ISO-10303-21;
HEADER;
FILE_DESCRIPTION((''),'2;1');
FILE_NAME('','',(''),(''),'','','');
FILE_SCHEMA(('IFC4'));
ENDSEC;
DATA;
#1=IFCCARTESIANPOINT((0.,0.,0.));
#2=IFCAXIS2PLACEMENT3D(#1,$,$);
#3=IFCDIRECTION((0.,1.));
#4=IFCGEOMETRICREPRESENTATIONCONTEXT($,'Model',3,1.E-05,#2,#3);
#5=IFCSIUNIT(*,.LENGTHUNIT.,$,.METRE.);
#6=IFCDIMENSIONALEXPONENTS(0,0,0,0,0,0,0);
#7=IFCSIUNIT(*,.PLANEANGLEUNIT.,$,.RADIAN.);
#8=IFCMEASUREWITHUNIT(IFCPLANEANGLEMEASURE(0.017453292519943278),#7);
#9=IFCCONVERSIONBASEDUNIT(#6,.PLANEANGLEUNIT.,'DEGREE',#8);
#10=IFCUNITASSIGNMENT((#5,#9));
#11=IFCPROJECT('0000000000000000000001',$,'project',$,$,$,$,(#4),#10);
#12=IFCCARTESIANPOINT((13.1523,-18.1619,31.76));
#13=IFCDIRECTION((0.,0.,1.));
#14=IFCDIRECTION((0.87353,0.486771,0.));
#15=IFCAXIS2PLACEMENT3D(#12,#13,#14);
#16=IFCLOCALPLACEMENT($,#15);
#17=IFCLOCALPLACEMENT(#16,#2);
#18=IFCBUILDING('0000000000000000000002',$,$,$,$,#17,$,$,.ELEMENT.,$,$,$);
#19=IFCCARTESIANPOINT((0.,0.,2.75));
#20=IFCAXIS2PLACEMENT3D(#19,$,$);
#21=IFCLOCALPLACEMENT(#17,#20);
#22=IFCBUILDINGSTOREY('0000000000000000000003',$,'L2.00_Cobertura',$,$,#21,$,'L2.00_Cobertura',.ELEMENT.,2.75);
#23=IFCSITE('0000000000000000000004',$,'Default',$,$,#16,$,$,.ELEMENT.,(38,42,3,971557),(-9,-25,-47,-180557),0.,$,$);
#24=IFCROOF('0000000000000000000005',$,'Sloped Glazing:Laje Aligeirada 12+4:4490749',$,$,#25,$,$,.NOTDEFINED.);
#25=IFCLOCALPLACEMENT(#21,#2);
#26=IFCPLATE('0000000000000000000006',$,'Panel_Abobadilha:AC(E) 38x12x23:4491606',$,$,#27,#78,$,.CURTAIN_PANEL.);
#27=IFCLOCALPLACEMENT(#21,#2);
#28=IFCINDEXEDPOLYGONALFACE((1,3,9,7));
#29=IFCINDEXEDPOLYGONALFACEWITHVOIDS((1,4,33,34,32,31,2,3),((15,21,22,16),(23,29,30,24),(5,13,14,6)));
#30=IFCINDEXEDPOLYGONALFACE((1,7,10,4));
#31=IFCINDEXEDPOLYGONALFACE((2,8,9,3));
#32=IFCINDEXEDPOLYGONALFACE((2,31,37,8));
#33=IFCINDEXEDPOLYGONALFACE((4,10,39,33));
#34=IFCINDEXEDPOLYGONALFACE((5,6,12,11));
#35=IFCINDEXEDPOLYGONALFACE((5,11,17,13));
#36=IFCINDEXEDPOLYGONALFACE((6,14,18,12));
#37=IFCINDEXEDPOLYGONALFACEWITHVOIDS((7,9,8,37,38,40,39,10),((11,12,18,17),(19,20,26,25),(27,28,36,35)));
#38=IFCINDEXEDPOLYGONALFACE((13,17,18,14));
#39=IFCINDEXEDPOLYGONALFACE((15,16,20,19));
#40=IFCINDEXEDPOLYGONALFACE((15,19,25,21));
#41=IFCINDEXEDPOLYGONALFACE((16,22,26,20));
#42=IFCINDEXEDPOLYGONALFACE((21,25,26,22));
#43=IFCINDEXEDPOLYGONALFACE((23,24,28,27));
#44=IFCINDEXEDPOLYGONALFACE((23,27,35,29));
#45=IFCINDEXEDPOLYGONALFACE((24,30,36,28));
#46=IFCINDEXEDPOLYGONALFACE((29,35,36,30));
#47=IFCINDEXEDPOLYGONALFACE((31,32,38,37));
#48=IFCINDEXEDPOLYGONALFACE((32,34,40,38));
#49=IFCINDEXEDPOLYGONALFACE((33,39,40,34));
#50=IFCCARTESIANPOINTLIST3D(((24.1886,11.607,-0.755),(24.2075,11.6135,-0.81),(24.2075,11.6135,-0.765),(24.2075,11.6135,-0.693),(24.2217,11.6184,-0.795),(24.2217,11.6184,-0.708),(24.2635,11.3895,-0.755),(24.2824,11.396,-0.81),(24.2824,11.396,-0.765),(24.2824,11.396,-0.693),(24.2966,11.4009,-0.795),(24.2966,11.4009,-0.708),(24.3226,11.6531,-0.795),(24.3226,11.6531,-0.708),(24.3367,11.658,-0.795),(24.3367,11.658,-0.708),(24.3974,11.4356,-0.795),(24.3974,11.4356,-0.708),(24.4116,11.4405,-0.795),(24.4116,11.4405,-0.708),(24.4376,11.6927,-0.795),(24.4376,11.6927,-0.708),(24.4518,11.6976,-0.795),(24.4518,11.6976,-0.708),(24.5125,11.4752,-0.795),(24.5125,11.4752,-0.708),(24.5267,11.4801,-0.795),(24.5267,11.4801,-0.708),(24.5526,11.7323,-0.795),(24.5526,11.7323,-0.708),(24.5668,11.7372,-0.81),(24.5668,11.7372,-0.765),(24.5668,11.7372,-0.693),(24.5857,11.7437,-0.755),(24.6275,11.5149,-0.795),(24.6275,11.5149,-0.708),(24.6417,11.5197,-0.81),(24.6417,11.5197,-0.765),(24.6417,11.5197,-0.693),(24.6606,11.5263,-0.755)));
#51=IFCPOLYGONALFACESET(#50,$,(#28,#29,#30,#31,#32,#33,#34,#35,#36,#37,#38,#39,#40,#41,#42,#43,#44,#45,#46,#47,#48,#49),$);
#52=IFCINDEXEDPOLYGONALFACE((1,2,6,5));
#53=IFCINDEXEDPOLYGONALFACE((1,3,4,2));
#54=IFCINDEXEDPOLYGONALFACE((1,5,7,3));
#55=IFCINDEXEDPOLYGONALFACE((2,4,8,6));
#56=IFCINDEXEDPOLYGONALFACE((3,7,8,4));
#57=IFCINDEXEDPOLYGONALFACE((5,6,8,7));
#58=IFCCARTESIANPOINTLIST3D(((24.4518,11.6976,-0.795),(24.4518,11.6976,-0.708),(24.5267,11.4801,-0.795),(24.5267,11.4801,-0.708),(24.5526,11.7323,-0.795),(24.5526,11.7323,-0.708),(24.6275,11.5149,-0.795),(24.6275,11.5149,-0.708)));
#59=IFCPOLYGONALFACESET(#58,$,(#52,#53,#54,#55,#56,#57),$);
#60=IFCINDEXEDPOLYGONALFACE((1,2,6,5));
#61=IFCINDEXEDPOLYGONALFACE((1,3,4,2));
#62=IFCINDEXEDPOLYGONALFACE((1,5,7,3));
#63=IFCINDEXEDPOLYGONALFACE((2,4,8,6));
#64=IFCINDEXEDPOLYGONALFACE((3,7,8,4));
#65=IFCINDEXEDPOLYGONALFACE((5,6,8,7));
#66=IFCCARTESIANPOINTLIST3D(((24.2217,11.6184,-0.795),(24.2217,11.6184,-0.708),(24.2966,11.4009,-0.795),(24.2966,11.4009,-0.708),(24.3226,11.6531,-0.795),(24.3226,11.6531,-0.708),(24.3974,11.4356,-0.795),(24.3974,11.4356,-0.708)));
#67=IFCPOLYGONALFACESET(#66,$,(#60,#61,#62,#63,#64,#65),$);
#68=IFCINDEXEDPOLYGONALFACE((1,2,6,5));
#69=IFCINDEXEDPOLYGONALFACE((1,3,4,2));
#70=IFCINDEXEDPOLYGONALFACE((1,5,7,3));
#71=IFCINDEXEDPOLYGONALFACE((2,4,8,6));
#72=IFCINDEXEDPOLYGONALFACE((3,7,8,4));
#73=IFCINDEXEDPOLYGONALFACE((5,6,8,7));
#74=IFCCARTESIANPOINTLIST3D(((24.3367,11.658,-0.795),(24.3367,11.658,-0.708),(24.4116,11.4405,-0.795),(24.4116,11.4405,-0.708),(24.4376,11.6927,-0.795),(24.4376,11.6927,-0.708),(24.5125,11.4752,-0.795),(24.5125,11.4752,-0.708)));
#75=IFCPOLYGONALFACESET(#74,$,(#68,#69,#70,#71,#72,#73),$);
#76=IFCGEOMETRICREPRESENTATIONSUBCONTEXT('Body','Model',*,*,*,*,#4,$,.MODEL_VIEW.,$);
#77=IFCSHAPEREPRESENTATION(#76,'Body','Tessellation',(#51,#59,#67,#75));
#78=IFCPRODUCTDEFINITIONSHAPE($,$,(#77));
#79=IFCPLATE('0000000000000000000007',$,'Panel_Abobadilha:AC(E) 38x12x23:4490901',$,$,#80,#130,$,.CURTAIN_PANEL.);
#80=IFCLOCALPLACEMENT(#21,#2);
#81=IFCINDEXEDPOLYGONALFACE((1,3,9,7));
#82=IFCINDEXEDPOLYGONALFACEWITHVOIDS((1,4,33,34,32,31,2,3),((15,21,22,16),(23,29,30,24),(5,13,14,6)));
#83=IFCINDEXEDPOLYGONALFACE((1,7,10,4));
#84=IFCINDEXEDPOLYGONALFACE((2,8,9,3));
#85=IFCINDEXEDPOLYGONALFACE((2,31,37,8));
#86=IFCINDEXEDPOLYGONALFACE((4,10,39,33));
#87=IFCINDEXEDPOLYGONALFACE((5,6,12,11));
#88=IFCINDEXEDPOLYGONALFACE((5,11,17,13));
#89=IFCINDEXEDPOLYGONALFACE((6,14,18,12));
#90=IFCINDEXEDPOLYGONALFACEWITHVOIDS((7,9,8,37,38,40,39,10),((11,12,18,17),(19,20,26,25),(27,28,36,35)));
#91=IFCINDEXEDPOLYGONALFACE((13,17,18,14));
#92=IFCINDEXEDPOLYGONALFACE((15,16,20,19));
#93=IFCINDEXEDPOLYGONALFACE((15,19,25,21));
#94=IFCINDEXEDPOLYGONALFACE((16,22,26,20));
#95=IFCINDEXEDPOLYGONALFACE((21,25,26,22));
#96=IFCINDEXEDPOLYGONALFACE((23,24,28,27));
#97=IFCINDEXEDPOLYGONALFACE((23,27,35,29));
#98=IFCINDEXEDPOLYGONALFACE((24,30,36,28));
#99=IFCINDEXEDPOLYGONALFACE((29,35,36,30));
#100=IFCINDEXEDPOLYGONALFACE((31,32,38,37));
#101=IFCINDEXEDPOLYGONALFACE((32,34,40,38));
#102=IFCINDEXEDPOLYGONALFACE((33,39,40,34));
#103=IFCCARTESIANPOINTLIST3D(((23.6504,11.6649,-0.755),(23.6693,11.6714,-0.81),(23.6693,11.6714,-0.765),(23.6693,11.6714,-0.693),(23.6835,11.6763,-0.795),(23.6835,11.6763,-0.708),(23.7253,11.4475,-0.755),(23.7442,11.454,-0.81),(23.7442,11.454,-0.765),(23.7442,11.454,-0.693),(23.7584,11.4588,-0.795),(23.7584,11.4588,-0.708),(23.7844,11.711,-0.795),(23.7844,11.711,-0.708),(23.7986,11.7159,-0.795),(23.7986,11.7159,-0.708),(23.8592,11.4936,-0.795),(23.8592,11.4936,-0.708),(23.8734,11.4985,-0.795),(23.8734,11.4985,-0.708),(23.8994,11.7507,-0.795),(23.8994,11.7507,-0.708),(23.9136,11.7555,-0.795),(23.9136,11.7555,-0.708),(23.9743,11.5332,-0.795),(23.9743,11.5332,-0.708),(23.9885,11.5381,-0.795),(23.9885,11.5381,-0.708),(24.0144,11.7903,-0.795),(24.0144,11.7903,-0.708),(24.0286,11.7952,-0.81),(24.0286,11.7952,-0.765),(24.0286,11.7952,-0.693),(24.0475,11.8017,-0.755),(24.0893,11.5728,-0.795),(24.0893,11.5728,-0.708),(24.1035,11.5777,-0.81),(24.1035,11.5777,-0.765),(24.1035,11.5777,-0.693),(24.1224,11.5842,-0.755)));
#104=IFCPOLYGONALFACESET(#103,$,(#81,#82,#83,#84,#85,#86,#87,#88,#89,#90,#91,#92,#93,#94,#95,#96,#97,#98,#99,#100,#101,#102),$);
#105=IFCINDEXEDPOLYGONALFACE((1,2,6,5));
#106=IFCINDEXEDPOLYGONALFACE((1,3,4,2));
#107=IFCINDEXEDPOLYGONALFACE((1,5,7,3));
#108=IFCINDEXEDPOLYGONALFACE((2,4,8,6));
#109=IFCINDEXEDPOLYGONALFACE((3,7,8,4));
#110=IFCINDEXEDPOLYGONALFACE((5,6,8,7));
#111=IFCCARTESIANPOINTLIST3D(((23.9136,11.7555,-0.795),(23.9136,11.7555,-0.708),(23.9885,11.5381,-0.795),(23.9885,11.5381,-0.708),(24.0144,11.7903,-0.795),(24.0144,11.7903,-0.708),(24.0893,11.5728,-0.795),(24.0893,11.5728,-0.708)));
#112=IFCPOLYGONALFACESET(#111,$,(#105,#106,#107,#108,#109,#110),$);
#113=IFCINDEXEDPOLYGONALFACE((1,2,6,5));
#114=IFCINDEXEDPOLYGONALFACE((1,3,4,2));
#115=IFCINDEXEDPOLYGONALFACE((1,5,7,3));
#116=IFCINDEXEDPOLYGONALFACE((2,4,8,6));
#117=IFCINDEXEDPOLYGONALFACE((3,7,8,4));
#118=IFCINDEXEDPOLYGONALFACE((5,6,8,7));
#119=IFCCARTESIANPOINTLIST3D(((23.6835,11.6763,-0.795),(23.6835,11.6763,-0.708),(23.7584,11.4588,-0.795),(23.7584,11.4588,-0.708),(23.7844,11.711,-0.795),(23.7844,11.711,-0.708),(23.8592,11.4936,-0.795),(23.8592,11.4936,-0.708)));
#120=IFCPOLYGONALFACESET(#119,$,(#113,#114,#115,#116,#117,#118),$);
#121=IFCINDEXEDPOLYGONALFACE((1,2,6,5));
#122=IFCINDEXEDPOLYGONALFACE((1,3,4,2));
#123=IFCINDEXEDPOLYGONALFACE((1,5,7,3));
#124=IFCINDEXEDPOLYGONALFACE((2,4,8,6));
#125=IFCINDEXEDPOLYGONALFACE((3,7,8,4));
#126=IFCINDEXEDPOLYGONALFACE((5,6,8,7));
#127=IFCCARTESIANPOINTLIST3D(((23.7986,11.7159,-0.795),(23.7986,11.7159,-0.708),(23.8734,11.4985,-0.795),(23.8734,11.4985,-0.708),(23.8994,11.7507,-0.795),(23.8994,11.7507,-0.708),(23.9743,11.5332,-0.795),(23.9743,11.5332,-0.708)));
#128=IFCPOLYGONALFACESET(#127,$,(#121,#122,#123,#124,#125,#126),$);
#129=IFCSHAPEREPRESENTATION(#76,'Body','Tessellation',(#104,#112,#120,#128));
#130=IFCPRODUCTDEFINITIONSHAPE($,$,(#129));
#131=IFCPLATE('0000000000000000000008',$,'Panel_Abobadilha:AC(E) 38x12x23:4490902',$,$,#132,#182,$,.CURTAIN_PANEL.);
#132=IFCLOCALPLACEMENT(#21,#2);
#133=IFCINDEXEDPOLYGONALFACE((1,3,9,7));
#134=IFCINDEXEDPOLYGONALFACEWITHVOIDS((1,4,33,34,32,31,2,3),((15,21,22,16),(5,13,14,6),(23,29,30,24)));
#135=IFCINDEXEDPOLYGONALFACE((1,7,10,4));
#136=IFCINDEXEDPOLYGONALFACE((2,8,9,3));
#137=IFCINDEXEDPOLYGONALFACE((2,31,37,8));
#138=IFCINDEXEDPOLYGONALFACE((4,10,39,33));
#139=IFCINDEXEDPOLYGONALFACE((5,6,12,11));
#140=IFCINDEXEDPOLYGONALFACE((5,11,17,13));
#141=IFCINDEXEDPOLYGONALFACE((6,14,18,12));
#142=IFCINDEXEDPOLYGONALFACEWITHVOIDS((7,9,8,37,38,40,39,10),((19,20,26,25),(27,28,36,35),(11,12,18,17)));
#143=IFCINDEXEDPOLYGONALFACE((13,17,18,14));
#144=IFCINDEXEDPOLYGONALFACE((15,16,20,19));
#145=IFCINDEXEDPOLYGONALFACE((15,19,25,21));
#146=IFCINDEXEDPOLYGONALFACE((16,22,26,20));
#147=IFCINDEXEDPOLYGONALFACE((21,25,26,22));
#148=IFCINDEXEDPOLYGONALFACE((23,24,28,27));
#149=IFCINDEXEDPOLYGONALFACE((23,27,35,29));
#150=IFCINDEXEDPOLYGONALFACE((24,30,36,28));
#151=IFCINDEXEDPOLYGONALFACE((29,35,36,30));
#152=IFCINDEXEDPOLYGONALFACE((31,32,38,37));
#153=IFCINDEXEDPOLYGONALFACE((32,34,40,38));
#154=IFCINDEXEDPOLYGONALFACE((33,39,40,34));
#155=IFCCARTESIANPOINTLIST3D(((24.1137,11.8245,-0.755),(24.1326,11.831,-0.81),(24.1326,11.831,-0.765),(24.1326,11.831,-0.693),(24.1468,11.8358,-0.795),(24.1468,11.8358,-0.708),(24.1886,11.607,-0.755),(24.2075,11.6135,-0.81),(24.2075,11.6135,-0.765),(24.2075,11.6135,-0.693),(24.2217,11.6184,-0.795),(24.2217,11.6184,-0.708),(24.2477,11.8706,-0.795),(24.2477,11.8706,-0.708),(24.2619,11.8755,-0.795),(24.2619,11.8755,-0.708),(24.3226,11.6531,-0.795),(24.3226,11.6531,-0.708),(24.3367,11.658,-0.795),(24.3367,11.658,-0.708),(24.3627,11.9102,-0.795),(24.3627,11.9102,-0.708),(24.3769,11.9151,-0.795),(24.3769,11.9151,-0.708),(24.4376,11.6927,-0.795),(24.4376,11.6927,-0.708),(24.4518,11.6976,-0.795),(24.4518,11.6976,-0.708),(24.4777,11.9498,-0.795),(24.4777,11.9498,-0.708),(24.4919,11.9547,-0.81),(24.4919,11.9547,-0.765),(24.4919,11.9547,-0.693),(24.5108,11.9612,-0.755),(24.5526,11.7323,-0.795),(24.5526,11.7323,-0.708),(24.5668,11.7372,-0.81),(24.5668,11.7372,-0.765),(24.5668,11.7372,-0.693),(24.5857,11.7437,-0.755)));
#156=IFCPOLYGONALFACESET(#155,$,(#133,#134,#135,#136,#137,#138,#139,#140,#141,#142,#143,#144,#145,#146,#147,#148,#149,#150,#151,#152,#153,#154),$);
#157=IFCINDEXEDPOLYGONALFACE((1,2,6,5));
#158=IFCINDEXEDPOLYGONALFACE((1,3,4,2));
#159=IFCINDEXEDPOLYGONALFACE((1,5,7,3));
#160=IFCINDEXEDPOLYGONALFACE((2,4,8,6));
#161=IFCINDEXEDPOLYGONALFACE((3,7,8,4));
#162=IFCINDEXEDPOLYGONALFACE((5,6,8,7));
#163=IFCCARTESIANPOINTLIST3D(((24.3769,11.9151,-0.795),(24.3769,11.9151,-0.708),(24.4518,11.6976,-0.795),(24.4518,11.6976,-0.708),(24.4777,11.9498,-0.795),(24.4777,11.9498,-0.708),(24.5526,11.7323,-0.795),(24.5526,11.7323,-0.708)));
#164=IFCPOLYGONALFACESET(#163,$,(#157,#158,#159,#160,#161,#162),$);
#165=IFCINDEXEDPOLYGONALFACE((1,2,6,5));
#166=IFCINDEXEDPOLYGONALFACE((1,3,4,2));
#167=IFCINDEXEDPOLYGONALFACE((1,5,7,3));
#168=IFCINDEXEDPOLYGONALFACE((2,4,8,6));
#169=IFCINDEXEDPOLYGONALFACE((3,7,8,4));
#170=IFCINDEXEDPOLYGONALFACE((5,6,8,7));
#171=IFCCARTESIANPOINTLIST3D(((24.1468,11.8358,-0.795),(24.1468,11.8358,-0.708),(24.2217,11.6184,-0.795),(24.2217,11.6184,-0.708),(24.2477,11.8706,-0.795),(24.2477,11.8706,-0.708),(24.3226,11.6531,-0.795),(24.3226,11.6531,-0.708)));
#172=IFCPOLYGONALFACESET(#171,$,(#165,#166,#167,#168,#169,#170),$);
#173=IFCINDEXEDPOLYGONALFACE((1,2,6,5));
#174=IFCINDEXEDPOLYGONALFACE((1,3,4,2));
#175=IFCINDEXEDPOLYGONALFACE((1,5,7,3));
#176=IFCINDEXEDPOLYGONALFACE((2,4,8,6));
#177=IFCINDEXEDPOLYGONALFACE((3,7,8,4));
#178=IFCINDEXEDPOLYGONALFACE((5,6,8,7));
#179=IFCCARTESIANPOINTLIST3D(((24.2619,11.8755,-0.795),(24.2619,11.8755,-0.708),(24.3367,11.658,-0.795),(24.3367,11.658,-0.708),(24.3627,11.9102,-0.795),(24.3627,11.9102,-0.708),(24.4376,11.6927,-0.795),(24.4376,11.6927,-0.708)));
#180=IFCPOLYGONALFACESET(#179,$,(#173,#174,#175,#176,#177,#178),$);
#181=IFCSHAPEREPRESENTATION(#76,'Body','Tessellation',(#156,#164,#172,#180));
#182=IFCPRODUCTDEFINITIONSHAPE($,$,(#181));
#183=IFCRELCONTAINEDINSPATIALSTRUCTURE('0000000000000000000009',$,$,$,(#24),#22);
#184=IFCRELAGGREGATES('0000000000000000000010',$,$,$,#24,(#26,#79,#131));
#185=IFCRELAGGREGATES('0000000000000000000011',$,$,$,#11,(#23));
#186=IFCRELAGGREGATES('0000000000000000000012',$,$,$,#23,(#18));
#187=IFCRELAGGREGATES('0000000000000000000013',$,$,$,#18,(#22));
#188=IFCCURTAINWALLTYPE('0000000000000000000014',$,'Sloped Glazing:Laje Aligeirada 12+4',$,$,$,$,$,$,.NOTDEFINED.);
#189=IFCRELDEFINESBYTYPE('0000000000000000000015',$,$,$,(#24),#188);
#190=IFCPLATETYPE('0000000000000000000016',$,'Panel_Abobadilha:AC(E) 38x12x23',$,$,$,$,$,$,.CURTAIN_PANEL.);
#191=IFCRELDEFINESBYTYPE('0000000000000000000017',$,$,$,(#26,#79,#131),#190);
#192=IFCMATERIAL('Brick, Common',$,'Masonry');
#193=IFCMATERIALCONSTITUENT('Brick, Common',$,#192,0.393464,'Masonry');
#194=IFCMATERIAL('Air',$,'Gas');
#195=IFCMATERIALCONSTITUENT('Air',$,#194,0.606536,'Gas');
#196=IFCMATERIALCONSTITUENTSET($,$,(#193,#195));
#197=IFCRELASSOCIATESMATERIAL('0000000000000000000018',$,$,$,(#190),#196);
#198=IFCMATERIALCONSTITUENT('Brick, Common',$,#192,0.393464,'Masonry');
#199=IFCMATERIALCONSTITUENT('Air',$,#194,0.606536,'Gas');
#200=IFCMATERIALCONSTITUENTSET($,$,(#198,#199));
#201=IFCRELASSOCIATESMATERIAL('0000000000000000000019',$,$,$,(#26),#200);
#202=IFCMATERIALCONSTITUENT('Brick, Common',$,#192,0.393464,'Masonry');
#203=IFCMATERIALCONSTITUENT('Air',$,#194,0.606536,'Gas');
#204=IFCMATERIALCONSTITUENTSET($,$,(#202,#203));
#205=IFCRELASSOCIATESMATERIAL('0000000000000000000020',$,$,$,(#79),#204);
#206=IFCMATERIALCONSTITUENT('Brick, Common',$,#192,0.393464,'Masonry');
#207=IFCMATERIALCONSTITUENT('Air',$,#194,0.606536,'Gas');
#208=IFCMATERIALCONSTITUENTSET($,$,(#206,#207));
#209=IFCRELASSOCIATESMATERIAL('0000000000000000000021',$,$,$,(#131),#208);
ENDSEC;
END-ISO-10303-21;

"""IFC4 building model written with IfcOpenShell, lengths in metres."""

from ifc_helpers import new_model, entity, si_unit, converted_unit, direction, frame, origin, place, context, subcontext, project, spatial, indexed_curve, outline, extrude, source, transform, mapped, material, constituent, constituent_set, type_object, type_shapes, element, aggregate, save


model = new_model("IFC4")

# Units and contexts
model_context = context("Model", 3, precision=1e-05, world=origin(), true_north=direction((0.0, 1.0)))
body_context = subcontext(model_context, "Body", "Model", "MODEL_VIEW")
ifc_project = project(units=[si_unit("LENGTHUNIT", "METRE"), converted_unit("PLANEANGLEUNIT", "DEGREE", entity("IfcPlaneAngleMeasure", 0.017453292519943278), si_unit("PLANEANGLEUNIT", "RADIAN"), dimensions=[0, 0, 0, 0, 0, 0, 0])], contexts=[model_context])

# Site, building, storey
site_placement = place(None, frame((13.1523, -18.1619, 31.76), z_axis=(0.0, 0.0, 1.0), x_axis=(0.87353, 0.486771, 0.0)))
site = spatial("IfcSite", under=ifc_project, at=site_placement, Name="Default", CompositionType="ELEMENT", RefLatitude=(38, 42, 3, 971557), RefLongitude=(-9, -25, -47, -180557), RefElevation=0.0)
building_placement = place(site_placement, origin())
building = spatial("IfcBuilding", under=site, at=building_placement, CompositionType="ELEMENT")
storey_placement = place(building_placement, frame((0.0, 0.0, 2.75)))
storey = spatial("IfcBuildingStorey", under=building, at=storey_placement, Name="L2.00_Cobertura", LongName="L2.00_Cobertura", CompositionType="ELEMENT", Elevation=2.75)

# Roof, plates
curtain_wall_type = type_object("IfcCurtainWallType", Name="Sloped Glazing:Laje Aligeirada 12+4", PredefinedType="NOTDEFINED")
roof_placement = place(storey_placement, frame((0.0, 0.0, -2.75)))
roof = element("IfcRoof", 1, at=roof_placement, inside=storey, type_object=curtain_wall_type, Name="Sloped Glazing:Laje Aligeirada 12+4:4490749", PredefinedType="NOTDEFINED")
ifc_material_1 = material(Name="Brick, Common", Category="Masonry")
ifc_material_2 = material(Name="Air", Category="Gas")
ifc_constituent_1 = constituent(ifc_material_1, Name="Brick, Common", Category="Masonry", fraction=0.393464)
ifc_constituent_2 = constituent(ifc_material_2, Name="Air", Category="Gas", fraction=0.606536)
ifc_constituent_set_1 = constituent_set(constituents=[ifc_constituent_1, ifc_constituent_2])
plate_type_1 = type_object("IfcPlateType", Name="Panel_Abobadilha:AC(E) 38x12x23", PredefinedType="CURTAIN_PANEL", material=ifc_constituent_set_1)
shared_shape_1 = source(origin(), body_context, "Body", "SweptSolid", [
    extrude(outline(indexed_curve([(-0.19, -0.0543), (0.19, -0.0543), (0.19, -0.0093), (0.21, 0.0007), (0.19, 0.0628), (-0.19, 0.0628), (-0.21, 0.0007), (-0.19, -0.0093), (-0.19, -0.0543)], self_intersect=False), holes=[indexed_curve([(-0.0683, 0.0477), (-0.0683, -0.0393), (-0.175, -0.0393), (-0.175, 0.0477), (-0.0683, 0.0477)], self_intersect=False), indexed_curve([(0.0533, 0.0477), (0.0533, -0.0393), (-0.0533, -0.0393), (-0.0533, 0.0477), (0.0533, 0.0477)], self_intersect=False), indexed_curve([(0.175, 0.0477), (0.175, -0.0393), (0.0683, -0.0393), (0.0683, 0.0477), (0.175, 0.0477)], self_intersect=False)]), frame((0.0, 0.0543, 0.0)), (0.0, 0.0, 1.0), 0.23),
    extrude(outline(indexed_curve([(-0.0533, -0.0435), (0.0533, -0.0435), (0.0533, 0.0435), (-0.0533, 0.0435), (-0.0533, -0.0435)], self_intersect=False)), frame((0.1217, 0.0585, 0.0), z_axis=(0.0, 0.0, 1.0), x_axis=(-1.0, 0.0, 0.0)), (0.0, 0.0, 1.0), 0.23),
    extrude(outline(indexed_curve([(-0.0533, -0.0435), (0.0533, -0.0435), (0.0533, 0.0435), (-0.0533, 0.0435), (-0.0533, -0.0435)], self_intersect=False)), frame((-0.1217, 0.0585, 0.0), z_axis=(0.0, 0.0, 1.0), x_axis=(-1.0, 0.0, 0.0)), (0.0, 0.0, 1.0), 0.23),
    extrude(outline(indexed_curve([(-0.0533, -0.0435), (0.0533, -0.0435), (0.0533, 0.0435), (-0.0533, 0.0435), (-0.0533, -0.0435)], self_intersect=False)), frame((0.0, 0.0585, 0.0), z_axis=(0.0, 0.0, 1.0), x_axis=(-1.0, 0.0, 0.0)), (0.0, 0.0, 1.0), 0.23),
])
type_shapes(plate_type_1, [shared_shape_1])
ifc_constituent_3 = constituent(ifc_material_1, Name="Brick, Common", Category="Masonry", fraction=0.393464)
ifc_constituent_4 = constituent(ifc_material_2, Name="Air", Category="Gas", fraction=0.606536)
ifc_constituent_set_2 = constituent_set(constituents=[ifc_constituent_3, ifc_constituent_4])
plate_1_placement = place(roof_placement, frame((24.3872, 11.6754, 1.94), z_axis=(0.325568, -0.945519, 0.0), x_axis=(0.945519, 0.325568, 0.0)))
plate_1 = element("IfcPlate", 2, at=plate_1_placement, type_object=plate_type_1, material=ifc_constituent_set_2, Name="Panel_Abobadilha:AC(E) 38x12x23:4491606", PredefinedType="CURTAIN_PANEL", context=body_context, shape_type="MappedRepresentation", body=[
    mapped(shared_shape_1, transform((0.0, 0.0, 0.0), scale=1.0)),
])
ifc_constituent_5 = constituent(ifc_material_1, Name="Brick, Common", Category="Masonry", fraction=0.393464)
ifc_constituent_6 = constituent(ifc_material_2, Name="Air", Category="Gas", fraction=0.606536)
ifc_constituent_set_3 = constituent_set(constituents=[ifc_constituent_5, ifc_constituent_6])
plate_2_placement = place(roof_placement, frame((23.849, 11.7333, 1.94), z_axis=(0.325568, -0.945519, 0.0), x_axis=(0.945519, 0.325568, 0.0)))
plate_2 = element("IfcPlate", 3, at=plate_2_placement, type_object=plate_type_1, material=ifc_constituent_set_3, Name="Panel_Abobadilha:AC(E) 38x12x23:4490901", PredefinedType="CURTAIN_PANEL", context=body_context, shape_type="MappedRepresentation", body=[
    mapped(shared_shape_1, transform((0.0, 0.0, 0.0), scale=1.0)),
])
ifc_constituent_7 = constituent(ifc_material_1, Name="Brick, Common", Category="Masonry", fraction=0.393464)
ifc_constituent_8 = constituent(ifc_material_2, Name="Air", Category="Gas", fraction=0.606536)
ifc_constituent_set_4 = constituent_set(constituents=[ifc_constituent_7, ifc_constituent_8])
plate_3_placement = place(roof_placement, frame((24.3123, 11.8928, 1.94), z_axis=(0.325568, -0.945519, 0.0), x_axis=(0.945519, 0.325568, 0.0)))
plate_3 = element("IfcPlate", 4, at=plate_3_placement, type_object=plate_type_1, material=ifc_constituent_set_4, Name="Panel_Abobadilha:AC(E) 38x12x23:4490902", PredefinedType="CURTAIN_PANEL", context=body_context, shape_type="MappedRepresentation", body=[
    mapped(shared_shape_1, transform((0.0, 0.0, 0.0), scale=1.0)),
])
aggregate(roof, [plate_1, plate_2, plate_3])

save(model, "model.ifc")
